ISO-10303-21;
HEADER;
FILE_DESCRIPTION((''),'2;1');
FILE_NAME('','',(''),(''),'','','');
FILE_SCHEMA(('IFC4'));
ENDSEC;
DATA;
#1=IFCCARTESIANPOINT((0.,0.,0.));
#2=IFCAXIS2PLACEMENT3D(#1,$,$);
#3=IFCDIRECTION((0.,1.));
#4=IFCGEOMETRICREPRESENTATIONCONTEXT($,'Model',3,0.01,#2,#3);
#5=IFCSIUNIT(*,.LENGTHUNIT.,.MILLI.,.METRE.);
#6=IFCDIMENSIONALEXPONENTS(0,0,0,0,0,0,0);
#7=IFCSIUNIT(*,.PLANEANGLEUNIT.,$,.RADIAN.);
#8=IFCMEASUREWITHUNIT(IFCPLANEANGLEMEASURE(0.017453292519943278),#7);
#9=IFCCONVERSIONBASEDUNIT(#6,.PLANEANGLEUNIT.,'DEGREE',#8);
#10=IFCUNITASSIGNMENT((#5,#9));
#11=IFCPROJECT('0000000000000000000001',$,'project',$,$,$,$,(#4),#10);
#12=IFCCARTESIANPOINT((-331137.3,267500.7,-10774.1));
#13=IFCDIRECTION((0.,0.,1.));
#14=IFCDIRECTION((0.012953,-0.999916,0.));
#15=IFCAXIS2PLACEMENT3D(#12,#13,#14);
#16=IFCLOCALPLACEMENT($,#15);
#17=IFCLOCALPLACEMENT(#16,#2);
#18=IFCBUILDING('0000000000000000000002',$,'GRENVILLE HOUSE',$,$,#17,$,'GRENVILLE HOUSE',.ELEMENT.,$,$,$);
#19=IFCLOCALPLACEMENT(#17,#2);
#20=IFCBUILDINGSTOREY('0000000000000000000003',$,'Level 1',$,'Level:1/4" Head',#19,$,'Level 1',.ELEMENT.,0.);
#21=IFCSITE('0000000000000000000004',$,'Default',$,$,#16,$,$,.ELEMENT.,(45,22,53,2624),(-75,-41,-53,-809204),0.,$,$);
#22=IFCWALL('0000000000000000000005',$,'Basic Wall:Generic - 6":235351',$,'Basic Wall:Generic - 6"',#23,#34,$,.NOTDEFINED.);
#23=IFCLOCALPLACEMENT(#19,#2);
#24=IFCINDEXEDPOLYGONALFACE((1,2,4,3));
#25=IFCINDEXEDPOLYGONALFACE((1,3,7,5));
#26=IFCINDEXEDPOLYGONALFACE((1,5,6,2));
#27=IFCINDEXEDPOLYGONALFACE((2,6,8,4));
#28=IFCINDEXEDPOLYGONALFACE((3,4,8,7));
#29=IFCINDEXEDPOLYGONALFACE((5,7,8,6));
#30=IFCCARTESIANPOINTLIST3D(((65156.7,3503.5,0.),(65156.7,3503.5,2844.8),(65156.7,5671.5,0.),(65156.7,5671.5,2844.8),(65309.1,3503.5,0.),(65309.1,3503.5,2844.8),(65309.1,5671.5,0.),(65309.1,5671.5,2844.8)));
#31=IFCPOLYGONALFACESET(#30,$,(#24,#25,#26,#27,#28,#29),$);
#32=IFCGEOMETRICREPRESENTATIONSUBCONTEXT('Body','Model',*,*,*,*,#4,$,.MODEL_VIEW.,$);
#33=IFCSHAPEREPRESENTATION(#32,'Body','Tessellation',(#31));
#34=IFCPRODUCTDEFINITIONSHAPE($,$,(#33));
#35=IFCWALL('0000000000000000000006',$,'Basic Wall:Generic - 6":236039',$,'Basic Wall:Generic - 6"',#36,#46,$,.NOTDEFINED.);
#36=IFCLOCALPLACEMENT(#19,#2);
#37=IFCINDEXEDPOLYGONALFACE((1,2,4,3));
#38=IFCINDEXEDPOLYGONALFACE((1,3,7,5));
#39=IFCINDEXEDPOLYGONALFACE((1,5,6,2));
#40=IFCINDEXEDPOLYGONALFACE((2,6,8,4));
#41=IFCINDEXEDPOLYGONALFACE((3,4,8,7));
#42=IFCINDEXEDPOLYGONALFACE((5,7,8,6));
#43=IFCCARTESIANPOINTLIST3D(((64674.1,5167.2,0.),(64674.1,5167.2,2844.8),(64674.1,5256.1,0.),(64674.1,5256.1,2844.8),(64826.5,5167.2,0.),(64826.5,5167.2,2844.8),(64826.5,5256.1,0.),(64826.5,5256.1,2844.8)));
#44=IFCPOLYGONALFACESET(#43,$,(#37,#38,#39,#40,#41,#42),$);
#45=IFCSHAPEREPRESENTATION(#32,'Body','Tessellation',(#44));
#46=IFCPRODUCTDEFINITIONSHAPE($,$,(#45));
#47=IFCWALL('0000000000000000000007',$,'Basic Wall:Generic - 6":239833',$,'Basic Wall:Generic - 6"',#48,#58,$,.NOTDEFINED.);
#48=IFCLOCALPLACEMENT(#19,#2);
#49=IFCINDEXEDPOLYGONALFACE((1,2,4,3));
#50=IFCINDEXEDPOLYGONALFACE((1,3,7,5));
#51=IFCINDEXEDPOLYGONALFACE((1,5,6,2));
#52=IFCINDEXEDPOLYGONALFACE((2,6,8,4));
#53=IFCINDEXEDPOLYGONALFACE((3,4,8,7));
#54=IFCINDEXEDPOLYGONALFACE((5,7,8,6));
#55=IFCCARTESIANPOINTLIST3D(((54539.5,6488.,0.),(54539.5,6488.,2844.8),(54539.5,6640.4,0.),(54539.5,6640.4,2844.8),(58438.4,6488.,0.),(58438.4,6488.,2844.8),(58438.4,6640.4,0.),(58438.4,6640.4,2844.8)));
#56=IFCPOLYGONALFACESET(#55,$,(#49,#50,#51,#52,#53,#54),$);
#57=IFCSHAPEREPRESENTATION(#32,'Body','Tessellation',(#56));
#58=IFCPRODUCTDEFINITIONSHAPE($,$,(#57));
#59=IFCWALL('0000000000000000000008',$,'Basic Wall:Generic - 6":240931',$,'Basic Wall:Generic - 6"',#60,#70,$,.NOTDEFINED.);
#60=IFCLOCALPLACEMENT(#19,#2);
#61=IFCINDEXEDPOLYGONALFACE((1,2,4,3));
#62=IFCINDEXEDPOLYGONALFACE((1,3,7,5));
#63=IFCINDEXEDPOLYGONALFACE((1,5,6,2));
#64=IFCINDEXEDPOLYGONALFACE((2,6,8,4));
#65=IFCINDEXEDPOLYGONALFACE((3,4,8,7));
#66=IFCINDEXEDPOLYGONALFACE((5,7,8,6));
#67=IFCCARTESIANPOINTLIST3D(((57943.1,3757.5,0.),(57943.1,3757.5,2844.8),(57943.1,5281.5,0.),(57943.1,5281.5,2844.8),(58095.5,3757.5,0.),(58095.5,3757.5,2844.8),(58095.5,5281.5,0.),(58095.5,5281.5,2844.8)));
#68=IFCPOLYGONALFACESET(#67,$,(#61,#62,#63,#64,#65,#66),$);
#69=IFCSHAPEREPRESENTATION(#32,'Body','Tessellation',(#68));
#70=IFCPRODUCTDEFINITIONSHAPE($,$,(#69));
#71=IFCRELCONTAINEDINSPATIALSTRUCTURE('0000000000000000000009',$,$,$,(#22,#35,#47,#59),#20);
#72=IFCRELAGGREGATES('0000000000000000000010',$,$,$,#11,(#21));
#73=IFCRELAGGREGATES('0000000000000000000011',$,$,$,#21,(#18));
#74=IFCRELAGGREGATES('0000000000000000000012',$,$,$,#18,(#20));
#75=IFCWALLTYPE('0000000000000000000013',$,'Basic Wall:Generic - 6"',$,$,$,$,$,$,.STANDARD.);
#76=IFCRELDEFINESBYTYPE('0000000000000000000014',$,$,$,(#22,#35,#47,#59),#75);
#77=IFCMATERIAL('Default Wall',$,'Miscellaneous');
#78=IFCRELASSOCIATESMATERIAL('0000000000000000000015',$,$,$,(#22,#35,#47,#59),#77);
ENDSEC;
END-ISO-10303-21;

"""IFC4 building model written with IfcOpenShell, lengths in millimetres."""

from ifc_helpers import new_model, entity, si_unit, converted_unit, direction, frame, origin, place, context, subcontext, project, spatial, indexed_curve, outline, extrude, material, type_object, element, save


model = new_model("IFC4")

# Units and contexts
model_context = context("Model", 3, precision=0.01, world=origin(), true_north=direction((0.0, 1.0)))
body_context = subcontext(model_context, "Body", "Model", "MODEL_VIEW")
ifc_project = project(units=[si_unit("LENGTHUNIT", "METRE", prefix="MILLI"), converted_unit("PLANEANGLEUNIT", "DEGREE", entity("IfcPlaneAngleMeasure", 0.017453292519943278), si_unit("PLANEANGLEUNIT", "RADIAN"), dimensions=[0, 0, 0, 0, 0, 0, 0])], contexts=[model_context])

# Site, building, storey
site_placement = place(None, frame((-331137.3, 267500.7, -10774.1), z_axis=(0.0, 0.0, 1.0), x_axis=(0.012953, -0.999916, 0.0)))
site = spatial("IfcSite", under=ifc_project, at=site_placement, Name="Default", CompositionType="ELEMENT", RefLatitude=(45, 22, 53, 2624), RefLongitude=(-75, -41, -53, -809204), RefElevation=0.0)
building_placement = place(site_placement, origin())
building = spatial("IfcBuilding", under=site, at=building_placement, Name="GRENVILLE HOUSE", LongName="GRENVILLE HOUSE", CompositionType="ELEMENT")
storey_placement = place(building_placement, origin())
storey = spatial("IfcBuildingStorey", under=building, at=storey_placement, Name="Level 1", ObjectType="Level:1/4\" Head", LongName="Level 1", CompositionType="ELEMENT", Elevation=0.0)

# Walls
ifc_material_1 = material(Name="Default Wall", Category="Miscellaneous")
wall_type = type_object("IfcWallType", Name="Basic Wall:Generic - 6\"", PredefinedType="STANDARD")
wall_1_placement = place(storey_placement, frame((65232.9, 5671.5, 0.0), z_axis=(0.0, 0.0, 1.0), x_axis=(0.0, -1.0, 0.0)))
element("IfcWall", 1, at=wall_1_placement, inside=storey, type_object=wall_type, material=ifc_material_1, Name="Basic Wall:Generic - 6\":235351", ObjectType="Basic Wall:Generic - 6\"", PredefinedType="NOTDEFINED", context=body_context, shape_type="SweptSolid", body=[
    extrude(outline(indexed_curve([(2168.0, 76.2), (0.0, 76.2), (0.0, -76.2), (2168.0, -76.2), (2168.0, 76.2)], self_intersect=False)), origin(), (0.0, 0.0, 1.0), 2844.8),
])
wall_2_placement = place(storey_placement, frame((64750.3, 5167.2, 0.0), z_axis=(0.0, 0.0, 1.0), x_axis=(0.0, 1.0, 0.0)))
element("IfcWall", 2, at=wall_2_placement, inside=storey, type_object=wall_type, material=ifc_material_1, Name="Basic Wall:Generic - 6\":236039", ObjectType="Basic Wall:Generic - 6\"", PredefinedType="NOTDEFINED", context=body_context, shape_type="SweptSolid", body=[
    extrude(outline(indexed_curve([(88.9, 76.2), (0.0, 76.2), (0.0, -76.2), (88.9, -76.2), (88.9, 76.2)], self_intersect=False)), origin(), (0.0, 0.0, 1.0), 2844.8),
])
wall_3_placement = place(storey_placement, frame((58438.4, 6564.2, 0.0), z_axis=(0.0, 0.0, 1.0), x_axis=(-1.0, 0.0, 0.0)))
element("IfcWall", 3, at=wall_3_placement, inside=storey, type_object=wall_type, material=ifc_material_1, Name="Basic Wall:Generic - 6\":239833", ObjectType="Basic Wall:Generic - 6\"", PredefinedType="NOTDEFINED", context=body_context, shape_type="SweptSolid", body=[
    extrude(outline(indexed_curve([(3898.9, 76.2), (0.0, 76.2), (0.0, -76.2), (3898.9, -76.2), (3898.9, 76.2)], self_intersect=False)), origin(), (0.0, 0.0, 1.0), 2844.8),
])
wall_4_placement = place(storey_placement, frame((58019.3, 5281.5, 0.0), z_axis=(0.0, 0.0, 1.0), x_axis=(0.0, -1.0, 0.0)))
element("IfcWall", 4, at=wall_4_placement, inside=storey, type_object=wall_type, material=ifc_material_1, Name="Basic Wall:Generic - 6\":240931", ObjectType="Basic Wall:Generic - 6\"", PredefinedType="NOTDEFINED", context=body_context, shape_type="SweptSolid", body=[
    extrude(outline(indexed_curve([(1524.0, 76.2), (0.0, 76.2), (0.0, -76.2), (1524.0, -76.2), (1524.0, 76.2)], self_intersect=False)), origin(), (0.0, 0.0, 1.0), 2844.8),
])

save(model, "model.ifc")
